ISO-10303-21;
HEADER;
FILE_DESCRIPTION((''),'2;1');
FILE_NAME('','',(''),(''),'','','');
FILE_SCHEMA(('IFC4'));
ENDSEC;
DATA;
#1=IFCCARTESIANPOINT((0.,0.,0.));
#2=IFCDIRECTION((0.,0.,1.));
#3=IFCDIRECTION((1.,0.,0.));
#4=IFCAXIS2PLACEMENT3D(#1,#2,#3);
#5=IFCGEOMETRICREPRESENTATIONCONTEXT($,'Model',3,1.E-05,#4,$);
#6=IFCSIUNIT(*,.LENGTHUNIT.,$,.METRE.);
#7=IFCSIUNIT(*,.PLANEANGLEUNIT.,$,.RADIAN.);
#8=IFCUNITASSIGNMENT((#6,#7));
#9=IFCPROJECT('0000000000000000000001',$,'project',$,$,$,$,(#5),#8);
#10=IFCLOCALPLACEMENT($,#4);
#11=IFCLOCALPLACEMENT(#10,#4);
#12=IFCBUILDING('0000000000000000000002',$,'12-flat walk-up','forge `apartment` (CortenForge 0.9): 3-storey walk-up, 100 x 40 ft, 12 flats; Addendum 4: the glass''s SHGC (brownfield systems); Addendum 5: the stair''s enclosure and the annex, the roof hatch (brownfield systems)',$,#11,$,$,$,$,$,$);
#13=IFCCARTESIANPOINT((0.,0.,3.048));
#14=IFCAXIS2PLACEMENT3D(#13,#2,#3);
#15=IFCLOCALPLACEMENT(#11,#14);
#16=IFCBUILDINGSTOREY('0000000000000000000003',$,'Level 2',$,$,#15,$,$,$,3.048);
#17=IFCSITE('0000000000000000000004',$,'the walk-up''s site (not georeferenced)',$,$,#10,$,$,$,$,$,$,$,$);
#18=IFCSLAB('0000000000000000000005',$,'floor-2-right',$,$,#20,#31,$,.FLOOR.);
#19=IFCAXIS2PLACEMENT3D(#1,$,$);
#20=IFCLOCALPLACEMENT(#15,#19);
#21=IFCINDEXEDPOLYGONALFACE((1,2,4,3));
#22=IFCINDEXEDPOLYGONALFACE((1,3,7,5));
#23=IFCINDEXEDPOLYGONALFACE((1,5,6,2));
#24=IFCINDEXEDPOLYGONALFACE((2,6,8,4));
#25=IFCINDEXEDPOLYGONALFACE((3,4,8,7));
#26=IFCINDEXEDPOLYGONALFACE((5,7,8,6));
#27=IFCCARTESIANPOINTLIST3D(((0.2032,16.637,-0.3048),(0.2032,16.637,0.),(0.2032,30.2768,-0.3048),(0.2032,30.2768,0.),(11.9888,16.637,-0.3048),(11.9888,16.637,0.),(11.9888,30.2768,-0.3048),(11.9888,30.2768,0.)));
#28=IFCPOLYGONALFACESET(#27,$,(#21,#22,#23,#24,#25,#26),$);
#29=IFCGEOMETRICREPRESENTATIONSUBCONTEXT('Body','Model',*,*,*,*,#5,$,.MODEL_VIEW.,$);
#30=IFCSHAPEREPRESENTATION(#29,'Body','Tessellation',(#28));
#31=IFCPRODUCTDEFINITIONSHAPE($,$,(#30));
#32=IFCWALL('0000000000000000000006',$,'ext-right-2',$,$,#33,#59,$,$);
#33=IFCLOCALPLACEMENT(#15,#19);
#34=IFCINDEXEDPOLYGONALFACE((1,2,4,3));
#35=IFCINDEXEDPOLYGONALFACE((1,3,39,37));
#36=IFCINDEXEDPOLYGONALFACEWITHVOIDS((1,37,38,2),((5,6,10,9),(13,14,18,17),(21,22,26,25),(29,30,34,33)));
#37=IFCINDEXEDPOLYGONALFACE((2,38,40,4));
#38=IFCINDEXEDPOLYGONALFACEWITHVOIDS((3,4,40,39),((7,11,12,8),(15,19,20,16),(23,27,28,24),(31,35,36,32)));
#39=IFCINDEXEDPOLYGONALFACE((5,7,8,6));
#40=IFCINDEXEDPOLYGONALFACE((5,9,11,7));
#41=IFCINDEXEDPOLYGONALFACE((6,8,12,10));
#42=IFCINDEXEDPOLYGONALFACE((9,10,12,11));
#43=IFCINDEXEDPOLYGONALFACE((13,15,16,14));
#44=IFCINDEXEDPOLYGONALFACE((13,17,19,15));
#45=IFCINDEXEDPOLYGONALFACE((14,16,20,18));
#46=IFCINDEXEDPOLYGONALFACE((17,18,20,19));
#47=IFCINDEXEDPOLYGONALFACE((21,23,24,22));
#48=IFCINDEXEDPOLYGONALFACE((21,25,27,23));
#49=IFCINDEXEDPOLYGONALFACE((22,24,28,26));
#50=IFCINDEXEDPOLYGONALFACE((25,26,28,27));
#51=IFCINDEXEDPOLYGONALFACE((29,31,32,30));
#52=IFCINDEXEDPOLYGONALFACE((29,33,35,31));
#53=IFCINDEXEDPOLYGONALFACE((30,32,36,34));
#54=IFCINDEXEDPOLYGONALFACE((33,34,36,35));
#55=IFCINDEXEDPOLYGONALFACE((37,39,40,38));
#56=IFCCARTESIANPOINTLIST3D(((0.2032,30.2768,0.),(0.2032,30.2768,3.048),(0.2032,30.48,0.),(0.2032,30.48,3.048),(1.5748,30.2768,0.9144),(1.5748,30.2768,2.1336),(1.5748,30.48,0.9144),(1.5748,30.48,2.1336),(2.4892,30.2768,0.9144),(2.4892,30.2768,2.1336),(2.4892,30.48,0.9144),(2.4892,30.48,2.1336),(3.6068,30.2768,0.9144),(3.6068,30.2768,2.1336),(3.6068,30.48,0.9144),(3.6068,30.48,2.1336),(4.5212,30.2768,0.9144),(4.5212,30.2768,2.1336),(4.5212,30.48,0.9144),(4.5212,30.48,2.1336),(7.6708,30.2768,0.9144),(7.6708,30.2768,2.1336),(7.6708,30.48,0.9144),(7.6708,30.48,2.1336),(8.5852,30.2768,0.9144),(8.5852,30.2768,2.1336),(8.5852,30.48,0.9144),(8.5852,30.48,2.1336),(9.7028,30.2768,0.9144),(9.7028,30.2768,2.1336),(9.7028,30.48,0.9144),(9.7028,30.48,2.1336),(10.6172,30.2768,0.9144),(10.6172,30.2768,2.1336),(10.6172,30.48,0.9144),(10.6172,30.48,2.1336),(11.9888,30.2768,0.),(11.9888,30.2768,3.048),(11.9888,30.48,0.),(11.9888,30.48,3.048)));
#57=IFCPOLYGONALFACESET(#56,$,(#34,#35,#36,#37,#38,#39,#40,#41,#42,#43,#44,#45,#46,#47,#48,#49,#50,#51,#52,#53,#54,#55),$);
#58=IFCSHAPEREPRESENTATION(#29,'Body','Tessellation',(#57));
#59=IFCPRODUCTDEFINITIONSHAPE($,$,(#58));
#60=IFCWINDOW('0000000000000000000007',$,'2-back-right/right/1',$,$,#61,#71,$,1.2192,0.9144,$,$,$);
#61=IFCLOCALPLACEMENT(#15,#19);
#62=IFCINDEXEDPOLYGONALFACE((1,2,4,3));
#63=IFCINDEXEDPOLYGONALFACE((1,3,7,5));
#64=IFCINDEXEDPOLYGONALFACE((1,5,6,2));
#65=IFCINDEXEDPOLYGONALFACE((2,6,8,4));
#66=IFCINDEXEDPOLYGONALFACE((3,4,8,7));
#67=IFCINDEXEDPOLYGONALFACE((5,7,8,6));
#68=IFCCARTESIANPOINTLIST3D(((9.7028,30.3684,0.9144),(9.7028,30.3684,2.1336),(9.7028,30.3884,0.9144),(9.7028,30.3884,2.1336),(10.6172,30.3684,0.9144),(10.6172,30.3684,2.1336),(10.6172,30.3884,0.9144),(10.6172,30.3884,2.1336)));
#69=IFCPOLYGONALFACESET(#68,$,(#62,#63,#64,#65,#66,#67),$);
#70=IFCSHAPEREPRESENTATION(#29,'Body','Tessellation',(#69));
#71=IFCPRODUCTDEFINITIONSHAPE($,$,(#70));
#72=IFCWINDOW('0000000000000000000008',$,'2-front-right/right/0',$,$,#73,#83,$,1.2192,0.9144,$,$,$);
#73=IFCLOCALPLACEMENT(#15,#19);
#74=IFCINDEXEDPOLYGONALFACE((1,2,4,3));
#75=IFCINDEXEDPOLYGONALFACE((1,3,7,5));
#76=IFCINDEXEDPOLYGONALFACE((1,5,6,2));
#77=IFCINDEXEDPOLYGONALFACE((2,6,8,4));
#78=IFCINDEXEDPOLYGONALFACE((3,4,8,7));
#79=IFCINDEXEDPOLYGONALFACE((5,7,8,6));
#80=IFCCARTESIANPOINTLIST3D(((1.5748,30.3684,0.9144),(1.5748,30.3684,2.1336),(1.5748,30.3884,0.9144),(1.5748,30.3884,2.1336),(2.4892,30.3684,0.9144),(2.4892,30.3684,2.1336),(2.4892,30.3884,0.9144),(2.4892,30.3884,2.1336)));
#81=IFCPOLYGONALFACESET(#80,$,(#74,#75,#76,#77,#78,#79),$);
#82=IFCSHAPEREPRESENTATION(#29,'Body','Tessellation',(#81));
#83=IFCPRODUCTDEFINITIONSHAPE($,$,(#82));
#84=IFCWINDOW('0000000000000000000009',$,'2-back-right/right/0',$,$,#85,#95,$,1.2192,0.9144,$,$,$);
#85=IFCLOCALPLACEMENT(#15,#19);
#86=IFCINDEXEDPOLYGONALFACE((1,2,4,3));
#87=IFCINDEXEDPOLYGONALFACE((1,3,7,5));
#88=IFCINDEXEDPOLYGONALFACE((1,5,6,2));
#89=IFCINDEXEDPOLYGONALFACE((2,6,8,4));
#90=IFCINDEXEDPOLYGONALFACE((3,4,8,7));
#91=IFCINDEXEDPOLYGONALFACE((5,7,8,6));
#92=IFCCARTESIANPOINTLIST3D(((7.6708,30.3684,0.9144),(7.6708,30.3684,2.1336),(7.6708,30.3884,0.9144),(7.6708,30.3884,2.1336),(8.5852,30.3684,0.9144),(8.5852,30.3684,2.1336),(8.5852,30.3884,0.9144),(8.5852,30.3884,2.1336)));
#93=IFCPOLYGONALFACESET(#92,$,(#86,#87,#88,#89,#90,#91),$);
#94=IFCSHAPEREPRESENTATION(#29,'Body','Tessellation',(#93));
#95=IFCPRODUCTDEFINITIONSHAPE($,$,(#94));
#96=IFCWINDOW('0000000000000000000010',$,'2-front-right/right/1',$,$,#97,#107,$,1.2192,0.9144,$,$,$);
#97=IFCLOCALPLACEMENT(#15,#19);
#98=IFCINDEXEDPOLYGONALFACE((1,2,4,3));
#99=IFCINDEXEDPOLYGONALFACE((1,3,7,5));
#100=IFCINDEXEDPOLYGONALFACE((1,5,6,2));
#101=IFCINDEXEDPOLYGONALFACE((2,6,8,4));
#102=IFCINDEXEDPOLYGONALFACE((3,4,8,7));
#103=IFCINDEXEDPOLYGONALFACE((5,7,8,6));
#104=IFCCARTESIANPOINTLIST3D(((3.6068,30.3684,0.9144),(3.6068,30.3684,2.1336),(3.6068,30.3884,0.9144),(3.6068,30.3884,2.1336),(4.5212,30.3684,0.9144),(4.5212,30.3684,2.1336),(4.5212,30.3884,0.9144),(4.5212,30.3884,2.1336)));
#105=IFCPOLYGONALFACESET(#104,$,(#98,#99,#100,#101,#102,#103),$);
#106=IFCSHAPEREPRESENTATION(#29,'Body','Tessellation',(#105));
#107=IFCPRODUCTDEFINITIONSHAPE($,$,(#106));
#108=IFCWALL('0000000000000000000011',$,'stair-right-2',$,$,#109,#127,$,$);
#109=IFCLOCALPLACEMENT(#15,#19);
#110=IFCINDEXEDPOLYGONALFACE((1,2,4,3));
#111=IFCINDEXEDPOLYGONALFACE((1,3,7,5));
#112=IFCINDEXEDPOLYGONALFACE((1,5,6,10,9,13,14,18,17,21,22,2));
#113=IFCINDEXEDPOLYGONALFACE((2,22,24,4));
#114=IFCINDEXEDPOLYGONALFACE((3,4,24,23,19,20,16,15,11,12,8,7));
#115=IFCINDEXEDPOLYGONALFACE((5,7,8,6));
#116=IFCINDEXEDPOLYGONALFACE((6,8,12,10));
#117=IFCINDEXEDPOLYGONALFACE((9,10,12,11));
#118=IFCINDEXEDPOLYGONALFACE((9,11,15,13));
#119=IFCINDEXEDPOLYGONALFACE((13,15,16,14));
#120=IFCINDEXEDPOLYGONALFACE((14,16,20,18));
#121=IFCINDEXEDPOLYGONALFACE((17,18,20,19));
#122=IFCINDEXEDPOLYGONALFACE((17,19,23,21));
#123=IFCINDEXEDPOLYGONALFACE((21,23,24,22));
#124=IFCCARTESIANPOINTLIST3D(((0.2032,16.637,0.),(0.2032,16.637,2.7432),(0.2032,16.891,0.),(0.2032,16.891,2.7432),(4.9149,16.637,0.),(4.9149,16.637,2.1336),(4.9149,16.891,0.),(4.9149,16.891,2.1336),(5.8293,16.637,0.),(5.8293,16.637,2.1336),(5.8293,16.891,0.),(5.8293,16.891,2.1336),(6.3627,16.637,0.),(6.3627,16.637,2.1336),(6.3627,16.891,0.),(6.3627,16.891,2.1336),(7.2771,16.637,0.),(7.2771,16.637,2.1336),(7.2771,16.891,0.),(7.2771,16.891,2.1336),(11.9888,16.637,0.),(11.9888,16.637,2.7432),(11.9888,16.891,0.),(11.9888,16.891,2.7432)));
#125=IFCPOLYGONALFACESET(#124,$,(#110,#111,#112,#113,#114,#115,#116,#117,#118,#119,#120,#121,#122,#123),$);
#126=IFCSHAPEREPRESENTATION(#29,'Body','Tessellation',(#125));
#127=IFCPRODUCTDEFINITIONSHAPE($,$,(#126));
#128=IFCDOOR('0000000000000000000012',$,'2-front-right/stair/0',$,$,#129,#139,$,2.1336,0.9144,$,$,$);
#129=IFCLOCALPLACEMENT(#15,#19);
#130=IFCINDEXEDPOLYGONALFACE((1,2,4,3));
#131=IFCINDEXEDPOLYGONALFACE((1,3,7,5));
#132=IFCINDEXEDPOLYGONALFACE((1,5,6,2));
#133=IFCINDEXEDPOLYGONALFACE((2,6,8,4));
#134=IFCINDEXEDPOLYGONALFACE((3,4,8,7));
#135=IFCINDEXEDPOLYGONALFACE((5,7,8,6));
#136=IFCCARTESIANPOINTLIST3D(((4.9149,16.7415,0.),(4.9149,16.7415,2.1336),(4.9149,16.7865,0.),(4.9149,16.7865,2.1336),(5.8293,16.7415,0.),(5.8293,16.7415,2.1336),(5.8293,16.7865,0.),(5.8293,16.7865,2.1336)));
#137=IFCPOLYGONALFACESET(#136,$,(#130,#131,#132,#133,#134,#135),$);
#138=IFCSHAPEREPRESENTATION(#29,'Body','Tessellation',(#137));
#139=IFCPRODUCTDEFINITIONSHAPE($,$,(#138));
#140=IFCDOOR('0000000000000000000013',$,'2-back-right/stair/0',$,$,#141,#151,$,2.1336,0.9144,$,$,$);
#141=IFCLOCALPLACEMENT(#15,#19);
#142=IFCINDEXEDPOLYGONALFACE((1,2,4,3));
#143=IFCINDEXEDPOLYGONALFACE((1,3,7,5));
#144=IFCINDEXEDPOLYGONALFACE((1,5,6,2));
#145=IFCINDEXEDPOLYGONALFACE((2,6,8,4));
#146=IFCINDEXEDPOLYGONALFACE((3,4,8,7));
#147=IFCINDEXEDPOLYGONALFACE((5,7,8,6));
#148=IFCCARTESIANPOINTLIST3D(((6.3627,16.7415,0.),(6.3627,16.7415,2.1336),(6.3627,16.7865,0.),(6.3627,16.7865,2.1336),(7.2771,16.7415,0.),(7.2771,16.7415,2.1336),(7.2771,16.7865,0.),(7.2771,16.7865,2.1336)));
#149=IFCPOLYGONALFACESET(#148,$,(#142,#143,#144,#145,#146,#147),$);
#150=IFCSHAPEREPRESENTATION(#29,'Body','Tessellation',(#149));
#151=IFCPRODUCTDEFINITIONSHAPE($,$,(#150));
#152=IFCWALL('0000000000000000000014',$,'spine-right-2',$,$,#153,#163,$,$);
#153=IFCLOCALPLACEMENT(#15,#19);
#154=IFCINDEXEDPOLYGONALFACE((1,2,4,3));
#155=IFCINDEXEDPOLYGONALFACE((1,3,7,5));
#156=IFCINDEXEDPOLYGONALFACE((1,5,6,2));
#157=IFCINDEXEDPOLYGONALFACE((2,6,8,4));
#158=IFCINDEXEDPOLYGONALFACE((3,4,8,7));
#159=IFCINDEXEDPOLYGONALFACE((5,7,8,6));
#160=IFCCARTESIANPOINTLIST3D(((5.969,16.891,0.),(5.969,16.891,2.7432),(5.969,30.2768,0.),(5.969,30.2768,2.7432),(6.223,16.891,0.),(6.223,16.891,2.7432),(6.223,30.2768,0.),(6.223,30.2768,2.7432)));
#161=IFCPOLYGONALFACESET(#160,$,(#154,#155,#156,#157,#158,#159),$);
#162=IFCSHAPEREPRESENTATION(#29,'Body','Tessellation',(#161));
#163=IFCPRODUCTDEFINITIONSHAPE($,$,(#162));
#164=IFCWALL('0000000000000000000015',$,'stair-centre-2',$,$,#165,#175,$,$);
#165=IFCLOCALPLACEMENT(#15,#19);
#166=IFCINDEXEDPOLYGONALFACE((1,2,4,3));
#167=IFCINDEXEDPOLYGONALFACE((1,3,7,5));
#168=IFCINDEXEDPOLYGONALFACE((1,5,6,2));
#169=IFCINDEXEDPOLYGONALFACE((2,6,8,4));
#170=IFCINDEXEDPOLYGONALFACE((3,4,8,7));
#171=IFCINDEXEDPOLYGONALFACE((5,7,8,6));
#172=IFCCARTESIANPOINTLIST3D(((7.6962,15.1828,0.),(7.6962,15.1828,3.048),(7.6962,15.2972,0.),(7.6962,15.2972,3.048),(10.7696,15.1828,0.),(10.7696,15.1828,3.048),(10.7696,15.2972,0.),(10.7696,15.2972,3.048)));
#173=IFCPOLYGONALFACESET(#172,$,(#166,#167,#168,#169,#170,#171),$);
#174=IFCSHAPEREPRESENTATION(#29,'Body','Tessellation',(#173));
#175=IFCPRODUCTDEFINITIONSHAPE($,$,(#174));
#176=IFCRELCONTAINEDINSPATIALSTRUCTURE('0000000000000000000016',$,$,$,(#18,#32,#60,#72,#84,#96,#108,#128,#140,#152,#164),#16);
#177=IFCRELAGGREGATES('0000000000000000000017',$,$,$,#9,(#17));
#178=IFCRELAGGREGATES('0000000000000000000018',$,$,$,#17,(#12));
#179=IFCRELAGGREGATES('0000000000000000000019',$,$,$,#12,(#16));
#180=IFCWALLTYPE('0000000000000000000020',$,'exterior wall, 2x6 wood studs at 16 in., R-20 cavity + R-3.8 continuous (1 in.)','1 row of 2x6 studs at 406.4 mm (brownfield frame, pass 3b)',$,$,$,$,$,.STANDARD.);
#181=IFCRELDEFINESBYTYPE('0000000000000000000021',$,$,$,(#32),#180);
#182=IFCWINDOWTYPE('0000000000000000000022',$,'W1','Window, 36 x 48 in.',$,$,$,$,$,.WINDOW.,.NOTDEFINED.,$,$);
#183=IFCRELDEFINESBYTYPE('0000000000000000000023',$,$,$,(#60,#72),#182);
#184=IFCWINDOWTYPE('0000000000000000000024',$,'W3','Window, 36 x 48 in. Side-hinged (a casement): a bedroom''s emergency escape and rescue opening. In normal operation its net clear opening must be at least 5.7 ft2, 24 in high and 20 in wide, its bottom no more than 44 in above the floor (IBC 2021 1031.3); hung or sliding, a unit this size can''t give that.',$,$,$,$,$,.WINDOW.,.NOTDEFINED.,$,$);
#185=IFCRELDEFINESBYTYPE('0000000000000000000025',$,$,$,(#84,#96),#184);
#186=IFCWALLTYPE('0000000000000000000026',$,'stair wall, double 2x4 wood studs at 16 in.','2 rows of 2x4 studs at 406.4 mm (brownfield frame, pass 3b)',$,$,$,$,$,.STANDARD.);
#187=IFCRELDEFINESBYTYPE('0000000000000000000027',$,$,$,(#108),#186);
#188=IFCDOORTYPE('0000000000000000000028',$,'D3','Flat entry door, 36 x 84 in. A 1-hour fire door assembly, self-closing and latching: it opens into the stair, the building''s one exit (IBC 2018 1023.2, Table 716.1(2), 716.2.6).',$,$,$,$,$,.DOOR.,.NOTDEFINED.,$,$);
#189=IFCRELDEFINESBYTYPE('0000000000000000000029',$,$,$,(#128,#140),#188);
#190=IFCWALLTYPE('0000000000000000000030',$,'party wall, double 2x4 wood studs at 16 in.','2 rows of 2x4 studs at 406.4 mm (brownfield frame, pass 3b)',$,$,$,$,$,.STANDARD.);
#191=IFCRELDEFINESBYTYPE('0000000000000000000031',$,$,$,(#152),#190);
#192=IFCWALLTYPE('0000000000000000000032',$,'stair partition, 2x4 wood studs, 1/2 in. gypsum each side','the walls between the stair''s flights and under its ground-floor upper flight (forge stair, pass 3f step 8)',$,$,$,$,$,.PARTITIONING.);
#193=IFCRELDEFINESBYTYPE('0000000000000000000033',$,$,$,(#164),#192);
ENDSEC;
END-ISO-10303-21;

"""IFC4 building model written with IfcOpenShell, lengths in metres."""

from ifc_helpers import new_model, si_unit, frame, frame_2d, origin, origin_with_axes, place, context, subcontext, project, spatial, rectangle, extrude, type_object, element, fill, save


model = new_model("IFC4")

# Units and contexts
model_context = context("Model", 3, precision=1e-05, world=origin_with_axes())
body_context = subcontext(model_context, "Body", "Model", "MODEL_VIEW")
ifc_project = project(units=[si_unit("LENGTHUNIT", "METRE"), si_unit("PLANEANGLEUNIT", "RADIAN")], contexts=[model_context])

# Site, building, storey
site_placement = place(None, origin_with_axes())
site = spatial("IfcSite", under=ifc_project, at=site_placement, Name="the walk-up's site (not georeferenced)")
building_placement = place(site_placement, origin_with_axes())
building = spatial("IfcBuilding", under=site, at=building_placement, Name="12-flat walk-up", Description="forge `apartment` (CortenForge 0.9): 3-storey walk-up, 100 x 40 ft, 12 flats; Addendum 4: the glass's SHGC (brownfield systems); Addendum 5: the stair's enclosure and the annex, the roof hatch (brownfield systems)")
storey_placement = place(building_placement, frame((0.0, 0.0, 3.048), z_axis=(0.0, 0.0, 1.0), x_axis=(1.0, 0.0, 0.0)))
storey = spatial("IfcBuildingStorey", under=building, at=storey_placement, Name="Level 2", Elevation=3.048)

# Slab
slab_placement = place(storey_placement, frame((0.2032, 16.637, -0.3048), z_axis=(0.0, 0.0, 1.0), x_axis=(1.0, 0.0, 0.0)))
element("IfcSlab", 1, at=slab_placement, inside=storey, Name="floor-2-right", PredefinedType="FLOOR", context=body_context, shape_type="SweptSolid", body=[
    extrude(rectangle(XDim=11.7856, YDim=13.6398, at=frame_2d((5.8928, 6.8199))), origin(), (0.0, 0.0, 1.0), 0.3048),
])

# Wall, openings, windows
wall_type_1 = type_object("IfcWallType", Name="exterior wall, 2x6 wood studs at 16 in., R-20 cavity + R-3.8 continuous (1 in.)", Description="1 row of 2x6 studs at 406.4 mm (brownfield frame, pass 3b)", PredefinedType="STANDARD")
wall_1_placement = place(storey_placement, frame((0.2032, 30.2768, 0.0), z_axis=(0.0, 0.0, 1.0), x_axis=(1.0, 0.0, 0.0)))
wall_1 = element("IfcWall", 2, at=wall_1_placement, inside=storey, type_object=wall_type_1, Name="ext-right-2", context=body_context, shape_type="SweptSolid", body=[
    extrude(rectangle(XDim=11.7856, YDim=0.2032, at=frame_2d((5.8928, 0.1016))), origin(), (0.0, 0.0, 1.0), 3.048),
])
opening_1_placement = place(wall_1_placement, frame((8.382, 0.2032, 0.9144), z_axis=(0.0, 0.0, 1.0), x_axis=(-1.0, 0.0, 0.0)))
opening_1 = element("IfcOpeningElement", 3, at=opening_1_placement, cuts=wall_1, PredefinedType="OPENING", context=body_context, shape_type="SweptSolid", body=[
    extrude(rectangle(XDim=0.9144, YDim=0.2032, at=frame_2d((0.4572, 0.1016))), origin(), (0.0, 0.0, 1.0), 1.2192),
])
opening_2_placement = place(wall_1_placement, frame((10.414, 0.2032, 0.9144), z_axis=(0.0, 0.0, 1.0), x_axis=(-1.0, 0.0, 0.0)))
opening_2 = element("IfcOpeningElement", 4, at=opening_2_placement, cuts=wall_1, PredefinedType="OPENING", context=body_context, shape_type="SweptSolid", body=[
    extrude(rectangle(XDim=0.9144, YDim=0.2032, at=frame_2d((0.4572, 0.1016))), origin(), (0.0, 0.0, 1.0), 1.2192),
])
opening_3_placement = place(wall_1_placement, frame((2.286, 0.2032, 0.9144), z_axis=(0.0, 0.0, 1.0), x_axis=(-1.0, 0.0, 0.0)))
opening_3 = element("IfcOpeningElement", 5, at=opening_3_placement, cuts=wall_1, PredefinedType="OPENING", context=body_context, shape_type="SweptSolid", body=[
    extrude(rectangle(XDim=0.9144, YDim=0.2032, at=frame_2d((0.4572, 0.1016))), origin(), (0.0, 0.0, 1.0), 1.2192),
])
opening_4_placement = place(wall_1_placement, frame((4.318, 0.2032, 0.9144), z_axis=(0.0, 0.0, 1.0), x_axis=(-1.0, 0.0, 0.0)))
opening_4 = element("IfcOpeningElement", 6, at=opening_4_placement, cuts=wall_1, PredefinedType="OPENING", context=body_context, shape_type="SweptSolid", body=[
    extrude(rectangle(XDim=0.9144, YDim=0.2032, at=frame_2d((0.4572, 0.1016))), origin(), (0.0, 0.0, 1.0), 1.2192),
])
window_type_1 = type_object("IfcWindowType", Name="W1", Description="Window, 36 x 48 in.", PartitioningType="NOTDEFINED", PredefinedType="WINDOW")
window_1_placement = place(opening_2_placement, frame((0.0, 0.0916, 0.0), z_axis=(0.0, 0.0, 1.0), x_axis=(1.0, 0.0, 0.0)))
window_1 = element("IfcWindow", 7, at=window_1_placement, inside=storey, type_object=window_type_1, Name="2-back-right/right/1", OverallHeight=1.2192, OverallWidth=0.9144, context=body_context, shape_type="SweptSolid", body=[
    extrude(rectangle(XDim=0.9144, YDim=0.02, at=frame_2d((0.4572, 0.01))), origin(), (0.0, 0.0, 1.0), 1.2192),
])
fill(opening_2, window_1)
window_2_placement = place(opening_3_placement, frame((0.0, 0.0916, 0.0), z_axis=(0.0, 0.0, 1.0), x_axis=(1.0, 0.0, 0.0)))
window_2 = element("IfcWindow", 8, at=window_2_placement, inside=storey, type_object=window_type_1, Name="2-front-right/right/0", OverallHeight=1.2192, OverallWidth=0.9144, context=body_context, shape_type="SweptSolid", body=[
    extrude(rectangle(XDim=0.9144, YDim=0.02, at=frame_2d((0.4572, 0.01))), origin(), (0.0, 0.0, 1.0), 1.2192),
])
fill(opening_3, window_2)
window_type_2 = type_object("IfcWindowType", Name="W3", Description="Window, 36 x 48 in. Side-hinged (a casement): a bedroom's emergency escape and rescue opening. In normal operation its net clear opening must be at least 5.7 ft2, 24 in high and 20 in wide, its bottom no more than 44 in above the floor (IBC 2021 1031.3); hung or sliding, a unit this size can't give that.", PartitioningType="NOTDEFINED", PredefinedType="WINDOW")
window_3_placement = place(opening_1_placement, frame((0.0, 0.0916, 0.0), z_axis=(0.0, 0.0, 1.0), x_axis=(1.0, 0.0, 0.0)))
window_3 = element("IfcWindow", 9, at=window_3_placement, inside=storey, type_object=window_type_2, Name="2-back-right/right/0", OverallHeight=1.2192, OverallWidth=0.9144, context=body_context, shape_type="SweptSolid", body=[
    extrude(rectangle(XDim=0.9144, YDim=0.02, at=frame_2d((0.4572, 0.01))), origin(), (0.0, 0.0, 1.0), 1.2192),
])
fill(opening_1, window_3)
window_4_placement = place(opening_4_placement, frame((0.0, 0.0916, 0.0), z_axis=(0.0, 0.0, 1.0), x_axis=(1.0, 0.0, 0.0)))
window_4 = element("IfcWindow", 10, at=window_4_placement, inside=storey, type_object=window_type_2, Name="2-front-right/right/1", OverallHeight=1.2192, OverallWidth=0.9144, context=body_context, shape_type="SweptSolid", body=[
    extrude(rectangle(XDim=0.9144, YDim=0.02, at=frame_2d((0.4572, 0.01))), origin(), (0.0, 0.0, 1.0), 1.2192),
])
fill(opening_4, window_4)

# Wall, openings, doors
wall_type_2 = type_object("IfcWallType", Name="stair wall, double 2x4 wood studs at 16 in.", Description="2 rows of 2x4 studs at 406.4 mm (brownfield frame, pass 3b)", PredefinedType="STANDARD")
wall_2_placement = place(storey_placement, frame((0.2032, 16.637, 0.0), z_axis=(0.0, 0.0, 1.0), x_axis=(1.0, 0.0, 0.0)))
wall_2 = element("IfcWall", 11, at=wall_2_placement, inside=storey, type_object=wall_type_2, Name="stair-right-2", context=body_context, shape_type="SweptSolid", body=[
    extrude(rectangle(XDim=11.7856, YDim=0.254, at=frame_2d((5.8928, 0.127))), origin(), (0.0, 0.0, 1.0), 2.7432),
])
opening_5_placement = place(wall_2_placement, frame((5.6261, 0.254, 0.0), z_axis=(0.0, 0.0, 1.0), x_axis=(-1.0, 0.0, 0.0)))
opening_5 = element("IfcOpeningElement", 12, at=opening_5_placement, cuts=wall_2, PredefinedType="OPENING", context=body_context, shape_type="SweptSolid", body=[
    extrude(rectangle(XDim=0.9144, YDim=0.254, at=frame_2d((0.4572, 0.127))), origin(), (0.0, 0.0, 1.0), 2.1336),
])
opening_6_placement = place(wall_2_placement, frame((7.0739, 0.254, 0.0), z_axis=(0.0, 0.0, 1.0), x_axis=(-1.0, 0.0, 0.0)))
opening_6 = element("IfcOpeningElement", 13, at=opening_6_placement, cuts=wall_2, PredefinedType="OPENING", context=body_context, shape_type="SweptSolid", body=[
    extrude(rectangle(XDim=0.9144, YDim=0.254, at=frame_2d((0.4572, 0.127))), origin(), (0.0, 0.0, 1.0), 2.1336),
])
door_type = type_object("IfcDoorType", Name="D3", Description="Flat entry door, 36 x 84 in. A 1-hour fire door assembly, self-closing and latching: it opens into the stair, the building's one exit (IBC 2018 1023.2, Table 716.1(2), 716.2.6).", OperationType="NOTDEFINED", PredefinedType="DOOR")
door_1_placement = place(opening_5_placement, frame((0.0, 0.1045, 0.0), z_axis=(0.0, 0.0, 1.0), x_axis=(1.0, 0.0, 0.0)))
door_1 = element("IfcDoor", 14, at=door_1_placement, inside=storey, type_object=door_type, Name="2-front-right/stair/0", OverallHeight=2.1336, OverallWidth=0.9144, context=body_context, shape_type="SweptSolid", body=[
    extrude(rectangle(XDim=0.9144, YDim=0.045, at=frame_2d((0.4572, 0.0225))), origin(), (0.0, 0.0, 1.0), 2.1336),
])
fill(opening_5, door_1)
door_2_placement = place(opening_6_placement, frame((0.0, 0.1045, 0.0), z_axis=(0.0, 0.0, 1.0), x_axis=(1.0, 0.0, 0.0)))
door_2 = element("IfcDoor", 15, at=door_2_placement, inside=storey, type_object=door_type, Name="2-back-right/stair/0", OverallHeight=2.1336, OverallWidth=0.9144, context=body_context, shape_type="SweptSolid", body=[
    extrude(rectangle(XDim=0.9144, YDim=0.045, at=frame_2d((0.4572, 0.0225))), origin(), (0.0, 0.0, 1.0), 2.1336),
])
fill(opening_6, door_2)

# Walls
wall_type_3 = type_object("IfcWallType", Name="party wall, double 2x4 wood studs at 16 in.", Description="2 rows of 2x4 studs at 406.4 mm (brownfield frame, pass 3b)", PredefinedType="STANDARD")
wall_3_placement = place(storey_placement, frame((5.969, 16.891, 0.0), z_axis=(0.0, 0.0, 1.0), x_axis=(1.0, 0.0, 0.0)))
element("IfcWall", 16, at=wall_3_placement, inside=storey, type_object=wall_type_3, Name="spine-right-2", context=body_context, shape_type="SweptSolid", body=[
    extrude(rectangle(XDim=0.254, YDim=13.3858, at=frame_2d((0.127, 6.6929))), origin(), (0.0, 0.0, 1.0), 2.7432),
])
wall_type_4 = type_object("IfcWallType", Name="stair partition, 2x4 wood studs, 1/2 in. gypsum each side", Description="the walls between the stair's flights and under its ground-floor upper flight (forge stair, pass 3f step 8)", PredefinedType="PARTITIONING")
wall_4_placement = place(storey_placement, frame((7.6962, 15.1829, 0.0), z_axis=(0.0, 0.0, 1.0), x_axis=(1.0, 0.0, 0.0)))
element("IfcWall", 17, at=wall_4_placement, inside=storey, type_object=wall_type_4, Name="stair-centre-2", context=body_context, shape_type="SweptSolid", body=[
    extrude(rectangle(XDim=3.0734, YDim=0.1143, at=frame_2d((1.5367, 0.0572))), origin(), (0.0, 0.0, 1.0), 3.048),
])

save(model, "model.ifc")
